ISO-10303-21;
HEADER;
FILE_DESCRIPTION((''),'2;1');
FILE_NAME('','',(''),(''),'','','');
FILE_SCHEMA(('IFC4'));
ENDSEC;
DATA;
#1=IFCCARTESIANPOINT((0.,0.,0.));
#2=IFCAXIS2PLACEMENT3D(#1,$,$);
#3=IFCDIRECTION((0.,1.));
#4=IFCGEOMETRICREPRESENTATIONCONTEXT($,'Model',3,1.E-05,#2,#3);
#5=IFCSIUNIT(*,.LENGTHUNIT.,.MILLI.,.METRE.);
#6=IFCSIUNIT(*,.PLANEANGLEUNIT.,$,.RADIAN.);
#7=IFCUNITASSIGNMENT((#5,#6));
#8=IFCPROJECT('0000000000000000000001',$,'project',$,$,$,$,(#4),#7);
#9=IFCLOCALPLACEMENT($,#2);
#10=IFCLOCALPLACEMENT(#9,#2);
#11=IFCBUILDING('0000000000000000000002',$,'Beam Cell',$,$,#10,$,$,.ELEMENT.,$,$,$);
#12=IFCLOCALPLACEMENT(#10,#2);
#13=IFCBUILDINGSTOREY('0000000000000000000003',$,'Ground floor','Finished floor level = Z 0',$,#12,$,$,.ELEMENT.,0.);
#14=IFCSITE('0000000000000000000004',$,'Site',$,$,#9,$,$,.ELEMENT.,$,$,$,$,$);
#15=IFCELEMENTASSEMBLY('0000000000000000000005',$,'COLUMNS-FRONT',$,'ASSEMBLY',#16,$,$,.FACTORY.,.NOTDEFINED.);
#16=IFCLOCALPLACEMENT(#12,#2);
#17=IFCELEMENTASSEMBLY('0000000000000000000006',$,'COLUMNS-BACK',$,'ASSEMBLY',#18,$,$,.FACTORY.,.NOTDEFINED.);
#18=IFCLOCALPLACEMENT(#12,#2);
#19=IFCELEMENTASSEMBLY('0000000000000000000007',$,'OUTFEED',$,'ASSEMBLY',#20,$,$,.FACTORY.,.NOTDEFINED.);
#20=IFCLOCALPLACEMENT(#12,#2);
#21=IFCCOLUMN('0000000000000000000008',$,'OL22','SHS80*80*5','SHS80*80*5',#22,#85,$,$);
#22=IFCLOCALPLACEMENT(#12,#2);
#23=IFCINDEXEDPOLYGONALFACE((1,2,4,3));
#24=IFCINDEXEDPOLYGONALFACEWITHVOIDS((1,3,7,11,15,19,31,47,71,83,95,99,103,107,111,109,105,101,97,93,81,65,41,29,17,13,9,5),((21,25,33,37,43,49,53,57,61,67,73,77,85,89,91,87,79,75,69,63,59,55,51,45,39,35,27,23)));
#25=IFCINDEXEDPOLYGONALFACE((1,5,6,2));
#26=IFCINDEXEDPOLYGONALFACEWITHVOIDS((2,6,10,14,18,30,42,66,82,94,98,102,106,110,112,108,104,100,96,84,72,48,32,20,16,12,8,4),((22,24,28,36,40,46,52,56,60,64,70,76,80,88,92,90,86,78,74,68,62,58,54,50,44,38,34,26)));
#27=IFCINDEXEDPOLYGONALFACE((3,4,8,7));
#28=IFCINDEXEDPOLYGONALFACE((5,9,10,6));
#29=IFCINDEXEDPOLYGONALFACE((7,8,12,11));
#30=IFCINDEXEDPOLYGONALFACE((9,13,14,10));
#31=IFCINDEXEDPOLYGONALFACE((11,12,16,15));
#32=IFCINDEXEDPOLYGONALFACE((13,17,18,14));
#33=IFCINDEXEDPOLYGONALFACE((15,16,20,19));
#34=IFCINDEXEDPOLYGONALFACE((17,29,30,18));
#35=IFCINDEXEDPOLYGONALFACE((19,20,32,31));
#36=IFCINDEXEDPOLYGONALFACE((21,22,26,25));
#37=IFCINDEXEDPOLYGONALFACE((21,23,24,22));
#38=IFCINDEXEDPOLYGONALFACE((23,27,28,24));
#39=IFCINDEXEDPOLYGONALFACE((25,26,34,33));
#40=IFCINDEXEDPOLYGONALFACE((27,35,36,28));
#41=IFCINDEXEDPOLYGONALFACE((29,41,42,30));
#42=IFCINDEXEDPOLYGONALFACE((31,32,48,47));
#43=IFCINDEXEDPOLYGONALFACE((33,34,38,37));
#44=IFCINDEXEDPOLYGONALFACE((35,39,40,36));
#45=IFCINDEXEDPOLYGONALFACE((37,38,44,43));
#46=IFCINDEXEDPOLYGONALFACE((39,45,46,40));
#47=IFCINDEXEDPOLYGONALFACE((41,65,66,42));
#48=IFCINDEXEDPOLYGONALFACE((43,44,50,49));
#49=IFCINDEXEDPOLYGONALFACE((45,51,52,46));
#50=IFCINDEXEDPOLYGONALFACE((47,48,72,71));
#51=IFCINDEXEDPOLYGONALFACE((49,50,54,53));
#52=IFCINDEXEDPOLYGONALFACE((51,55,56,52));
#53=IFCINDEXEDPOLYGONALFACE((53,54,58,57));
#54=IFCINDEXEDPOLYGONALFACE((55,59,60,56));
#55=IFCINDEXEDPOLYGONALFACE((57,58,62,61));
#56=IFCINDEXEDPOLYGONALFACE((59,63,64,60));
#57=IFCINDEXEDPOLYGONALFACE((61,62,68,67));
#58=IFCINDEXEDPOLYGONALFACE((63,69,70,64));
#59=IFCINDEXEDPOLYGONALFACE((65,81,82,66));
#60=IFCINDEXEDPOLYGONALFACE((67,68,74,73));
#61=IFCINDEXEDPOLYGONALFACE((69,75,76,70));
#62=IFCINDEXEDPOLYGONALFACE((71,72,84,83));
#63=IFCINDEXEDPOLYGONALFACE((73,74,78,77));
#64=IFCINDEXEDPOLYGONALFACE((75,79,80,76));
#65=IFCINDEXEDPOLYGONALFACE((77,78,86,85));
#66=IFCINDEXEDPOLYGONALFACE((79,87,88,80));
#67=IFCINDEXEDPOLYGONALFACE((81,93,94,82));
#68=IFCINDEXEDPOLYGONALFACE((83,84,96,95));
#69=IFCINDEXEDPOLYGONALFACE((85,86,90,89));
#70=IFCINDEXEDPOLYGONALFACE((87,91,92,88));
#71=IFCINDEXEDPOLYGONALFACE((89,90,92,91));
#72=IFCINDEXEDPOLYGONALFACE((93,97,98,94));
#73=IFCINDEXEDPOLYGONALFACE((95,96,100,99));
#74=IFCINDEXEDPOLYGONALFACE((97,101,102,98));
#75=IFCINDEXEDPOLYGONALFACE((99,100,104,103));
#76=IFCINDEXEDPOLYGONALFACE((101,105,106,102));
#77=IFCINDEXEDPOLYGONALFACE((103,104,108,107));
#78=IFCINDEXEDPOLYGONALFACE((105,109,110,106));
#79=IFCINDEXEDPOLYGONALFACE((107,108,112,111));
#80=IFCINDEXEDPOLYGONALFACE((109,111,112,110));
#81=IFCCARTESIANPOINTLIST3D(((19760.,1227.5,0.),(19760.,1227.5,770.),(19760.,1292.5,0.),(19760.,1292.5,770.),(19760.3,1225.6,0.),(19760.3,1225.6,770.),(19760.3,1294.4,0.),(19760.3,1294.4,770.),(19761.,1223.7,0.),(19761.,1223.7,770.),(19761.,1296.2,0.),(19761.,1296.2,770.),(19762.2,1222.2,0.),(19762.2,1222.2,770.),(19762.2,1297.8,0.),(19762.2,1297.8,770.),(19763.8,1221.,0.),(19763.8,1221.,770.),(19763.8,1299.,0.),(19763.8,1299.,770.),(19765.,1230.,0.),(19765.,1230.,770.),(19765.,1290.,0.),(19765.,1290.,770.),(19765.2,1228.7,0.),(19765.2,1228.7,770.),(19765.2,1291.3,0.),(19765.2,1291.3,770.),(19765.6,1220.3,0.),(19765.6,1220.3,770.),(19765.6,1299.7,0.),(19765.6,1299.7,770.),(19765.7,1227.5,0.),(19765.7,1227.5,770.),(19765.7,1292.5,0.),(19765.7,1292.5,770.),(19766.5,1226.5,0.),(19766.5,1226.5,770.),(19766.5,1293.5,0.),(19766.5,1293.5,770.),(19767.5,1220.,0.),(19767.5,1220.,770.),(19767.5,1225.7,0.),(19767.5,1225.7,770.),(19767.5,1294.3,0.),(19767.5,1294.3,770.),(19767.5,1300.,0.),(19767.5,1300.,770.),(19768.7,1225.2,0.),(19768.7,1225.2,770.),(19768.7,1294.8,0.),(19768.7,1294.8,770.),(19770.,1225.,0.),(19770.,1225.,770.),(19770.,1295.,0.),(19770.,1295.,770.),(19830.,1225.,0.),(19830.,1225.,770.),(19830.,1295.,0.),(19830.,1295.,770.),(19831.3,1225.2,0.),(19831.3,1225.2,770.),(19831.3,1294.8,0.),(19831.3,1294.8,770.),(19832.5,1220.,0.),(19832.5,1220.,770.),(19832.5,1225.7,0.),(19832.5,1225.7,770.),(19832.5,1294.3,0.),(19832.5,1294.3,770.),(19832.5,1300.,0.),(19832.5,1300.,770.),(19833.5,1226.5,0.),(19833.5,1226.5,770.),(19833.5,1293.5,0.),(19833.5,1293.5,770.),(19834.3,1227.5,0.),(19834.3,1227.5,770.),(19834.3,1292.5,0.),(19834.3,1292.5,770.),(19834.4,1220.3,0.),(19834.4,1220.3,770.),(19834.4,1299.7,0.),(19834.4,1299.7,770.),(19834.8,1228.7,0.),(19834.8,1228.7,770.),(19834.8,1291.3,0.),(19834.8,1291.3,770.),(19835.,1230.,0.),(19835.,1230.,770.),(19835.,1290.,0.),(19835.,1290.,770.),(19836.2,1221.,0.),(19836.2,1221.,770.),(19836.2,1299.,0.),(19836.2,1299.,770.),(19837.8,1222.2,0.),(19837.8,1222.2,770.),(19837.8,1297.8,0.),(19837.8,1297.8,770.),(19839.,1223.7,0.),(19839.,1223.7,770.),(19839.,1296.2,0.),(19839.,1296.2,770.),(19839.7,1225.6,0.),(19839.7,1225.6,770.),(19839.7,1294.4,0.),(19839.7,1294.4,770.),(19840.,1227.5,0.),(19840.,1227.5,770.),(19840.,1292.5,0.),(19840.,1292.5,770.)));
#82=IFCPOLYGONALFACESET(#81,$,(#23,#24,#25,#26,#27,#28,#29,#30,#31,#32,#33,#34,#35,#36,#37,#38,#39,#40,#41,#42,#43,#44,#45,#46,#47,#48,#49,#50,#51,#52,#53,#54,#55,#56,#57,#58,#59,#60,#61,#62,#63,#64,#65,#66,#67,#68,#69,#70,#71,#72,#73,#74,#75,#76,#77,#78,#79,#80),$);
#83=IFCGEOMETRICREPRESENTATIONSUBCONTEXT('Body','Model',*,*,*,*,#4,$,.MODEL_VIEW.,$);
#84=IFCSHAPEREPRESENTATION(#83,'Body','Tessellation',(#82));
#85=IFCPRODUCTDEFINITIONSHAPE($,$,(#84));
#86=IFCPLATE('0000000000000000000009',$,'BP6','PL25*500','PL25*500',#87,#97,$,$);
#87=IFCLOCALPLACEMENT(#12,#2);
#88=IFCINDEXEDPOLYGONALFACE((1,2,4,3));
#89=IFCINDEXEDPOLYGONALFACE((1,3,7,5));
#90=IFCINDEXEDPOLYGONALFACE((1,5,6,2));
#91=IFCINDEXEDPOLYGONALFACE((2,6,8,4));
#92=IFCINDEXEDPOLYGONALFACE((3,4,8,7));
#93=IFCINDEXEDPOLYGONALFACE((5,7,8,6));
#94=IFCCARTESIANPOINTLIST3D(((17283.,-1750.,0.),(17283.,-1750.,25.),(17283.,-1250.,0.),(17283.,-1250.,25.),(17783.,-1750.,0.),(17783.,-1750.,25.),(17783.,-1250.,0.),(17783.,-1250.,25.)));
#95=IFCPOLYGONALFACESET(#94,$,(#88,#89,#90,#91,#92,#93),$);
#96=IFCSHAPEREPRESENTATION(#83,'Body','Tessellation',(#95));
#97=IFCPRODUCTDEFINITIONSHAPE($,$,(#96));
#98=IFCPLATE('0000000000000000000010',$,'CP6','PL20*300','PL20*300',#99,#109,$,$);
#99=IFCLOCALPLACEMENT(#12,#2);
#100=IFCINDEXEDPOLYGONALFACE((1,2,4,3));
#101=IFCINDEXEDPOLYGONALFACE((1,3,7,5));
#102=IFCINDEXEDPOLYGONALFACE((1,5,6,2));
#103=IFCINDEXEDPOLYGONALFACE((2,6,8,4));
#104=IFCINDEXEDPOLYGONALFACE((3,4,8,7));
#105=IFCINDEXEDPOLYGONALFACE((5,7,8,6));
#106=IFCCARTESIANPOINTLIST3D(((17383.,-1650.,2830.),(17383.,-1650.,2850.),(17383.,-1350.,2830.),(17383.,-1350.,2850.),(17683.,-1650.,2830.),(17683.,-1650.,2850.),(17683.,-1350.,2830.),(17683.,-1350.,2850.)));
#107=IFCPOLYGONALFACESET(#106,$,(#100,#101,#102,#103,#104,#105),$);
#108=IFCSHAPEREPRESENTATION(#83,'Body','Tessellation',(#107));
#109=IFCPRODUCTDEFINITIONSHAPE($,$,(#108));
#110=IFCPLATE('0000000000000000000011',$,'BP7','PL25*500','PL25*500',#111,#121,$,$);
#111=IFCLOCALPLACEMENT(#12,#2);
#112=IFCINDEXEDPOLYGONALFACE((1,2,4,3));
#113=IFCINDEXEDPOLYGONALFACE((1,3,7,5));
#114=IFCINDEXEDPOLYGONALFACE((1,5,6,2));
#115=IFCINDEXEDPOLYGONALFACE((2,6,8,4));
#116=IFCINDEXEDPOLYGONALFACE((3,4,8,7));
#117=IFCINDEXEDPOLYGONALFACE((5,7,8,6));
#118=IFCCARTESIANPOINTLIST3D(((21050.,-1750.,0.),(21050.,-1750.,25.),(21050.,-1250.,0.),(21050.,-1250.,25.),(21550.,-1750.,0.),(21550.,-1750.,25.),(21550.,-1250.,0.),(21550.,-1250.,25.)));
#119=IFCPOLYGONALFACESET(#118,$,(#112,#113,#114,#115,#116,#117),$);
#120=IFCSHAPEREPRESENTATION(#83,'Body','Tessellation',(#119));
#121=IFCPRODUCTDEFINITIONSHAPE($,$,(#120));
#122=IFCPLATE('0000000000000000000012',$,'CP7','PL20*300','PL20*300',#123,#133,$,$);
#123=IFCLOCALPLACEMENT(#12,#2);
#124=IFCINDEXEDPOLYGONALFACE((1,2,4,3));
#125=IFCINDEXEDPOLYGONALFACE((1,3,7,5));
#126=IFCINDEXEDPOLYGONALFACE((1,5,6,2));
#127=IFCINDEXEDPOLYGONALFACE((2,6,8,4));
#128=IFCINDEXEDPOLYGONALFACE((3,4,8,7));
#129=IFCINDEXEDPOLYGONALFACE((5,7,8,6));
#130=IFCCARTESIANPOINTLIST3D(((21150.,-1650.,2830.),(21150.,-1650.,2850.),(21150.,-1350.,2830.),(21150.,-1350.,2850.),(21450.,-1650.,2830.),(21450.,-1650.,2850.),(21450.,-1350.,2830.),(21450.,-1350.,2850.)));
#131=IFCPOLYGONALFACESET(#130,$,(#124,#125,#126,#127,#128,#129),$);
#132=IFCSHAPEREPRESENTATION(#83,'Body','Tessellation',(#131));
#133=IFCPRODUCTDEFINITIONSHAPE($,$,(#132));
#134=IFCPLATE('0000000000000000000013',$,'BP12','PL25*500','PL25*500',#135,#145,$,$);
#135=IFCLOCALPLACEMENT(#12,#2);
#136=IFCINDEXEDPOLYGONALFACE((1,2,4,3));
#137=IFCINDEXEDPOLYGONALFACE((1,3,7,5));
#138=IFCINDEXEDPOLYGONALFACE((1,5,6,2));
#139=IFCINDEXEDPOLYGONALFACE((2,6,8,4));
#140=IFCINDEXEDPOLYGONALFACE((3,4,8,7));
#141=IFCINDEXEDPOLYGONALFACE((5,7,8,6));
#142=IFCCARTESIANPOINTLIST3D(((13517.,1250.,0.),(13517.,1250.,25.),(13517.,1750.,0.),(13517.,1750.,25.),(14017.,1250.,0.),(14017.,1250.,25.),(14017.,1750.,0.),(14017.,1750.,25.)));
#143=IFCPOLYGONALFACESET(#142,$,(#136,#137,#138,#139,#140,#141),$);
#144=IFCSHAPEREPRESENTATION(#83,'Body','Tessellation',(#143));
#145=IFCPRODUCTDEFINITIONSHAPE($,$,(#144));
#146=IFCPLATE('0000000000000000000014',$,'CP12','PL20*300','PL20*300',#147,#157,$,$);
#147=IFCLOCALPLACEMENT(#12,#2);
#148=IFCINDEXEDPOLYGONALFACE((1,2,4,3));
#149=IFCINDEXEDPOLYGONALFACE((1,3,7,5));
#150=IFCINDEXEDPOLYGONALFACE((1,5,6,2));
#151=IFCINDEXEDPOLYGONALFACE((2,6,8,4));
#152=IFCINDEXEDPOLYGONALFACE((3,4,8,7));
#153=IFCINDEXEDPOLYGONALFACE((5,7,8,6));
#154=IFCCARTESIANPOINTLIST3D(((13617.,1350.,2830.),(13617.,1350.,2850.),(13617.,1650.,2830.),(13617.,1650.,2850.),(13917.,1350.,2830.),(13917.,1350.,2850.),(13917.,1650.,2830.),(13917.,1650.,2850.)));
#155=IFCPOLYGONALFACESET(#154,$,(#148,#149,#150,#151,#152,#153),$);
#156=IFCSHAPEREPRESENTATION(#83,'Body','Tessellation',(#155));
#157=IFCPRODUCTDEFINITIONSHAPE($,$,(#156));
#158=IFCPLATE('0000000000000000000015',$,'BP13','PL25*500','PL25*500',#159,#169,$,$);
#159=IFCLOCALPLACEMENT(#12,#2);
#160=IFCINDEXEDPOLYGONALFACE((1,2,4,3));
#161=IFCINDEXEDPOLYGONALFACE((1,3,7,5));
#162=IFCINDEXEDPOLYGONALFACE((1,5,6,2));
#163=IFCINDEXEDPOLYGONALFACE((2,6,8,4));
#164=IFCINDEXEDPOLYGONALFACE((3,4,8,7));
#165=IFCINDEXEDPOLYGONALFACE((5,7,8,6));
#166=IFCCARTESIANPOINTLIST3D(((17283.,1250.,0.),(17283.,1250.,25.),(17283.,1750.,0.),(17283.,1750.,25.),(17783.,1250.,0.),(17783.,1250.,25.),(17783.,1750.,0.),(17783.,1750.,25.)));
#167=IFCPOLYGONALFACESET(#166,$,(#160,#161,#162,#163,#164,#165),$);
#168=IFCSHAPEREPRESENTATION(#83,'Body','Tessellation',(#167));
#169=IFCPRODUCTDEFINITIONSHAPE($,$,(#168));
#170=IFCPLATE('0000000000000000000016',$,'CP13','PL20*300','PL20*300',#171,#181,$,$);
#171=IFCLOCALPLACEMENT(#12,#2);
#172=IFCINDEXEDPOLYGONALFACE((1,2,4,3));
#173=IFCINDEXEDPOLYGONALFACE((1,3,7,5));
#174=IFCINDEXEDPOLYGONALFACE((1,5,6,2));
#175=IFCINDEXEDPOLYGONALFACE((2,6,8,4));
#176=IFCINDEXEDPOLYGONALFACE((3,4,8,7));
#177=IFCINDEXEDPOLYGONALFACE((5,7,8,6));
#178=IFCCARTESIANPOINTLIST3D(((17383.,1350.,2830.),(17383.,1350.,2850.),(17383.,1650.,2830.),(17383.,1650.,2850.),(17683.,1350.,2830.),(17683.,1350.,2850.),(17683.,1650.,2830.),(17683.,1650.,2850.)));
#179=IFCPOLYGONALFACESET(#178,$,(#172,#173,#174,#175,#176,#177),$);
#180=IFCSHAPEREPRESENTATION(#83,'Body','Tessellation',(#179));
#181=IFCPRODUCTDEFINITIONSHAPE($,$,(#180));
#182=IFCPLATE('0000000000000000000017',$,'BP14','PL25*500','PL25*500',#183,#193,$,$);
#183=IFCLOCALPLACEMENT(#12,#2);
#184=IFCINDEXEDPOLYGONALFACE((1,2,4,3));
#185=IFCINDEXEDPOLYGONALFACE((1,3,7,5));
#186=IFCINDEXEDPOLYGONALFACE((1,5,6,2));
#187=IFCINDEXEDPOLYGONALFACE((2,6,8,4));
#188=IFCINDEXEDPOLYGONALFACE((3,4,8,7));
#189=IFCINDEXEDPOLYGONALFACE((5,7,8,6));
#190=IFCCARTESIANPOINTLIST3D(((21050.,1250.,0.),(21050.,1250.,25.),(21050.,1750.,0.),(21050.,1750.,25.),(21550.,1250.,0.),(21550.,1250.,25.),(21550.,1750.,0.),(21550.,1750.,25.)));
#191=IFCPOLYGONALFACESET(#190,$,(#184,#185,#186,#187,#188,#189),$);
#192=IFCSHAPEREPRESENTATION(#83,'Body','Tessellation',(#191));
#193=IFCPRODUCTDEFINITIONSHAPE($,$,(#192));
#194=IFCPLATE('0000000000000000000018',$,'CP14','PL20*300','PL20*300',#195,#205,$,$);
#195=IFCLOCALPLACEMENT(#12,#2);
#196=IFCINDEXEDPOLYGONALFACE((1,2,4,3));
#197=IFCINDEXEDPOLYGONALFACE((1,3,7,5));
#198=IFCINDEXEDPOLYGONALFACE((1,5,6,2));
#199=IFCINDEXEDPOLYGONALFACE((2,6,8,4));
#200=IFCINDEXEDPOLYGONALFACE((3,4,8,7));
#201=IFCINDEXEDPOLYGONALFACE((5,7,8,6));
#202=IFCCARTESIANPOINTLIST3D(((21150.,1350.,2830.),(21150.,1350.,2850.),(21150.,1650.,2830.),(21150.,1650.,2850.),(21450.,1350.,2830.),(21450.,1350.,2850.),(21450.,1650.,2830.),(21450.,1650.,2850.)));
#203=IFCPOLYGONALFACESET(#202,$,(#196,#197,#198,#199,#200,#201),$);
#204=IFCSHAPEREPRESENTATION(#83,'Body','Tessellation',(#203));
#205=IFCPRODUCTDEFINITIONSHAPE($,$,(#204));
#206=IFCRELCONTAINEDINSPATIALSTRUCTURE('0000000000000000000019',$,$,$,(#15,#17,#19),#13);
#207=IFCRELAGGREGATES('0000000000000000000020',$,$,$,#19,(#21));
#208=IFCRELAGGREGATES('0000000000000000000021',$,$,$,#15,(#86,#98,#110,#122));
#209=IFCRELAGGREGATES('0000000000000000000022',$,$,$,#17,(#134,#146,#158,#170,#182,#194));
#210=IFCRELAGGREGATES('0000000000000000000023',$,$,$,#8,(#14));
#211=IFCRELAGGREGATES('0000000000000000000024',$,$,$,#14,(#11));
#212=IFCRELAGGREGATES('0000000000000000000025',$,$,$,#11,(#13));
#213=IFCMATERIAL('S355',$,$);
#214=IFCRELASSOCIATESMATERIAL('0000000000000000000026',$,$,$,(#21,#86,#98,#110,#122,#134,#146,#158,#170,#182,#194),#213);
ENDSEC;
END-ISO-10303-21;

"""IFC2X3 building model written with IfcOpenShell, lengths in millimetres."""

from ifc_helpers import new_model, si_unit, direction, frame, origin, origin_2d, place, context, subcontext, project, spatial, rectangle, hollow_rectangle, extrude, material, element, aggregate, save


model = new_model("IFC2X3")

# Units and contexts
model_context = context("Model", 3, precision=1e-05, world=origin(), true_north=direction((0.0, 1.0)))
body_context = subcontext(model_context, "Body", "Model", "MODEL_VIEW")
ifc_project = project(units=[si_unit("LENGTHUNIT", "METRE", prefix="MILLI"), si_unit("PLANEANGLEUNIT", "RADIAN")], contexts=[model_context])

# Site, building, storey
site_placement = place(None, origin())
site = spatial("IfcSite", under=ifc_project, at=site_placement, Name="Site", CompositionType="ELEMENT")
building_placement = place(site_placement, origin())
building = spatial("IfcBuilding", under=site, at=building_placement, Name="Beam Cell", CompositionType="ELEMENT")
storey_placement = place(building_placement, origin())
storey = spatial("IfcBuildingStorey", under=building, at=storey_placement, Name="Ground floor", Description="Finished floor level = Z 0", CompositionType="ELEMENT", Elevation=0.0)

# Element assemblies, column
assembly_1_placement = place(storey_placement, origin())
assembly_1 = element("IfcElementAssembly", 1, at=assembly_1_placement, inside=storey, Name="COLUMNS-FRONT", ObjectType="ASSEMBLY", AssemblyPlace="FACTORY", PredefinedType="NOTDEFINED")
ifc_material = material(Name="S355")
assembly_2_placement = place(storey_placement, origin())
assembly_2 = element("IfcElementAssembly", 2, at=assembly_2_placement, inside=storey, Name="COLUMNS-BACK", ObjectType="ASSEMBLY", AssemblyPlace="FACTORY", PredefinedType="NOTDEFINED")
assembly_3_placement = place(storey_placement, origin())
assembly_3 = element("IfcElementAssembly", 3, at=assembly_3_placement, inside=storey, Name="OUTFEED", ObjectType="ASSEMBLY", AssemblyPlace="FACTORY", PredefinedType="NOTDEFINED")
column_1_placement = place(storey_placement, frame((19800.0, 1260.0, 0.0), z_axis=(0.0, 0.0, 1.0), x_axis=(1.0, 0.0, 0.0)))
column_1 = element("IfcColumn", 4, at=column_1_placement, material=ifc_material, Name="OL22", Description="SHS80*80*5", ObjectType="SHS80*80*5", context=body_context, shape_type="SweptSolid", body=[
    extrude(hollow_rectangle(XDim=80.0, YDim=80.0, WallThickness=5.0, InnerFilletRadius=5.0, OuterFilletRadius=7.5, at=origin_2d()), origin(), (0.0, 0.0, 1.0), 770.0),
])
aggregate(assembly_3, [column_1])

# Plates
plate_1_placement = place(storey_placement, frame((17533.0, -1500.0, 0.0), z_axis=(0.0, 0.0, 1.0), x_axis=(1.0, 0.0, 0.0)))
plate_1 = element("IfcPlate", 5, at=plate_1_placement, material=ifc_material, Name="BP6", Description="PL25*500", ObjectType="PL25*500", context=body_context, shape_type="SweptSolid", body=[
    extrude(rectangle(XDim=500.0, YDim=500.0, at=origin_2d()), origin(), (0.0, 0.0, 1.0), 25.0),
])
plate_2_placement = place(storey_placement, frame((17533.0, -1500.0, 2830.0), z_axis=(0.0, 0.0, 1.0), x_axis=(1.0, 0.0, 0.0)))
plate_2 = element("IfcPlate", 6, at=plate_2_placement, material=ifc_material, Name="CP6", Description="PL20*300", ObjectType="PL20*300", context=body_context, shape_type="SweptSolid", body=[
    extrude(rectangle(XDim=300.0, YDim=300.0, at=origin_2d()), origin(), (0.0, 0.0, 1.0), 20.0),
])
plate_3_placement = place(storey_placement, frame((21300.0, -1500.0, 0.0), z_axis=(0.0, 0.0, 1.0), x_axis=(1.0, 0.0, 0.0)))
plate_3 = element("IfcPlate", 7, at=plate_3_placement, material=ifc_material, Name="BP7", Description="PL25*500", ObjectType="PL25*500", context=body_context, shape_type="SweptSolid", body=[
    extrude(rectangle(XDim=500.0, YDim=500.0, at=origin_2d()), origin(), (0.0, 0.0, 1.0), 25.0),
])
plate_4_placement = place(storey_placement, frame((21300.0, -1500.0, 2830.0), z_axis=(0.0, 0.0, 1.0), x_axis=(1.0, 0.0, 0.0)))
plate_4 = element("IfcPlate", 8, at=plate_4_placement, material=ifc_material, Name="CP7", Description="PL20*300", ObjectType="PL20*300", context=body_context, shape_type="SweptSolid", body=[
    extrude(rectangle(XDim=300.0, YDim=300.0, at=origin_2d()), origin(), (0.0, 0.0, 1.0), 20.0),
])
aggregate(assembly_1, [plate_1, plate_2, plate_3, plate_4])
plate_5_placement = place(storey_placement, frame((13767.0, 1500.0, 0.0), z_axis=(0.0, 0.0, 1.0), x_axis=(1.0, 0.0, 0.0)))
plate_5 = element("IfcPlate", 9, at=plate_5_placement, material=ifc_material, Name="BP12", Description="PL25*500", ObjectType="PL25*500", context=body_context, shape_type="SweptSolid", body=[
    extrude(rectangle(XDim=500.0, YDim=500.0, at=origin_2d()), origin(), (0.0, 0.0, 1.0), 25.0),
])
plate_6_placement = place(storey_placement, frame((13767.0, 1500.0, 2830.0), z_axis=(0.0, 0.0, 1.0), x_axis=(1.0, 0.0, 0.0)))
plate_6 = element("IfcPlate", 10, at=plate_6_placement, material=ifc_material, Name="CP12", Description="PL20*300", ObjectType="PL20*300", context=body_context, shape_type="SweptSolid", body=[
    extrude(rectangle(XDim=300.0, YDim=300.0, at=origin_2d()), origin(), (0.0, 0.0, 1.0), 20.0),
])
plate_7_placement = place(storey_placement, frame((17533.0, 1500.0, 0.0), z_axis=(0.0, 0.0, 1.0), x_axis=(1.0, 0.0, 0.0)))
plate_7 = element("IfcPlate", 11, at=plate_7_placement, material=ifc_material, Name="BP13", Description="PL25*500", ObjectType="PL25*500", context=body_context, shape_type="SweptSolid", body=[
    extrude(rectangle(XDim=500.0, YDim=500.0, at=origin_2d()), origin(), (0.0, 0.0, 1.0), 25.0),
])
plate_8_placement = place(storey_placement, frame((17533.0, 1500.0, 2830.0), z_axis=(0.0, 0.0, 1.0), x_axis=(1.0, 0.0, 0.0)))
plate_8 = element("IfcPlate", 12, at=plate_8_placement, material=ifc_material, Name="CP13", Description="PL20*300", ObjectType="PL20*300", context=body_context, shape_type="SweptSolid", body=[
    extrude(rectangle(XDim=300.0, YDim=300.0, at=origin_2d()), origin(), (0.0, 0.0, 1.0), 20.0),
])
plate_9_placement = place(storey_placement, frame((21300.0, 1500.0, 0.0), z_axis=(0.0, 0.0, 1.0), x_axis=(1.0, 0.0, 0.0)))
plate_9 = element("IfcPlate", 13, at=plate_9_placement, material=ifc_material, Name="BP14", Description="PL25*500", ObjectType="PL25*500", context=body_context, shape_type="SweptSolid", body=[
    extrude(rectangle(XDim=500.0, YDim=500.0, at=origin_2d()), origin(), (0.0, 0.0, 1.0), 25.0),
])
plate_10_placement = place(storey_placement, frame((21300.0, 1500.0, 2830.0), z_axis=(0.0, 0.0, 1.0), x_axis=(1.0, 0.0, 0.0)))
plate_10 = element("IfcPlate", 14, at=plate_10_placement, material=ifc_material, Name="CP14", Description="PL20*300", ObjectType="PL20*300", context=body_context, shape_type="SweptSolid", body=[
    extrude(rectangle(XDim=300.0, YDim=300.0, at=origin_2d()), origin(), (0.0, 0.0, 1.0), 20.0),
])
aggregate(assembly_2, [plate_5, plate_6, plate_7, plate_8, plate_9, plate_10])

save(model, "model.ifc")
